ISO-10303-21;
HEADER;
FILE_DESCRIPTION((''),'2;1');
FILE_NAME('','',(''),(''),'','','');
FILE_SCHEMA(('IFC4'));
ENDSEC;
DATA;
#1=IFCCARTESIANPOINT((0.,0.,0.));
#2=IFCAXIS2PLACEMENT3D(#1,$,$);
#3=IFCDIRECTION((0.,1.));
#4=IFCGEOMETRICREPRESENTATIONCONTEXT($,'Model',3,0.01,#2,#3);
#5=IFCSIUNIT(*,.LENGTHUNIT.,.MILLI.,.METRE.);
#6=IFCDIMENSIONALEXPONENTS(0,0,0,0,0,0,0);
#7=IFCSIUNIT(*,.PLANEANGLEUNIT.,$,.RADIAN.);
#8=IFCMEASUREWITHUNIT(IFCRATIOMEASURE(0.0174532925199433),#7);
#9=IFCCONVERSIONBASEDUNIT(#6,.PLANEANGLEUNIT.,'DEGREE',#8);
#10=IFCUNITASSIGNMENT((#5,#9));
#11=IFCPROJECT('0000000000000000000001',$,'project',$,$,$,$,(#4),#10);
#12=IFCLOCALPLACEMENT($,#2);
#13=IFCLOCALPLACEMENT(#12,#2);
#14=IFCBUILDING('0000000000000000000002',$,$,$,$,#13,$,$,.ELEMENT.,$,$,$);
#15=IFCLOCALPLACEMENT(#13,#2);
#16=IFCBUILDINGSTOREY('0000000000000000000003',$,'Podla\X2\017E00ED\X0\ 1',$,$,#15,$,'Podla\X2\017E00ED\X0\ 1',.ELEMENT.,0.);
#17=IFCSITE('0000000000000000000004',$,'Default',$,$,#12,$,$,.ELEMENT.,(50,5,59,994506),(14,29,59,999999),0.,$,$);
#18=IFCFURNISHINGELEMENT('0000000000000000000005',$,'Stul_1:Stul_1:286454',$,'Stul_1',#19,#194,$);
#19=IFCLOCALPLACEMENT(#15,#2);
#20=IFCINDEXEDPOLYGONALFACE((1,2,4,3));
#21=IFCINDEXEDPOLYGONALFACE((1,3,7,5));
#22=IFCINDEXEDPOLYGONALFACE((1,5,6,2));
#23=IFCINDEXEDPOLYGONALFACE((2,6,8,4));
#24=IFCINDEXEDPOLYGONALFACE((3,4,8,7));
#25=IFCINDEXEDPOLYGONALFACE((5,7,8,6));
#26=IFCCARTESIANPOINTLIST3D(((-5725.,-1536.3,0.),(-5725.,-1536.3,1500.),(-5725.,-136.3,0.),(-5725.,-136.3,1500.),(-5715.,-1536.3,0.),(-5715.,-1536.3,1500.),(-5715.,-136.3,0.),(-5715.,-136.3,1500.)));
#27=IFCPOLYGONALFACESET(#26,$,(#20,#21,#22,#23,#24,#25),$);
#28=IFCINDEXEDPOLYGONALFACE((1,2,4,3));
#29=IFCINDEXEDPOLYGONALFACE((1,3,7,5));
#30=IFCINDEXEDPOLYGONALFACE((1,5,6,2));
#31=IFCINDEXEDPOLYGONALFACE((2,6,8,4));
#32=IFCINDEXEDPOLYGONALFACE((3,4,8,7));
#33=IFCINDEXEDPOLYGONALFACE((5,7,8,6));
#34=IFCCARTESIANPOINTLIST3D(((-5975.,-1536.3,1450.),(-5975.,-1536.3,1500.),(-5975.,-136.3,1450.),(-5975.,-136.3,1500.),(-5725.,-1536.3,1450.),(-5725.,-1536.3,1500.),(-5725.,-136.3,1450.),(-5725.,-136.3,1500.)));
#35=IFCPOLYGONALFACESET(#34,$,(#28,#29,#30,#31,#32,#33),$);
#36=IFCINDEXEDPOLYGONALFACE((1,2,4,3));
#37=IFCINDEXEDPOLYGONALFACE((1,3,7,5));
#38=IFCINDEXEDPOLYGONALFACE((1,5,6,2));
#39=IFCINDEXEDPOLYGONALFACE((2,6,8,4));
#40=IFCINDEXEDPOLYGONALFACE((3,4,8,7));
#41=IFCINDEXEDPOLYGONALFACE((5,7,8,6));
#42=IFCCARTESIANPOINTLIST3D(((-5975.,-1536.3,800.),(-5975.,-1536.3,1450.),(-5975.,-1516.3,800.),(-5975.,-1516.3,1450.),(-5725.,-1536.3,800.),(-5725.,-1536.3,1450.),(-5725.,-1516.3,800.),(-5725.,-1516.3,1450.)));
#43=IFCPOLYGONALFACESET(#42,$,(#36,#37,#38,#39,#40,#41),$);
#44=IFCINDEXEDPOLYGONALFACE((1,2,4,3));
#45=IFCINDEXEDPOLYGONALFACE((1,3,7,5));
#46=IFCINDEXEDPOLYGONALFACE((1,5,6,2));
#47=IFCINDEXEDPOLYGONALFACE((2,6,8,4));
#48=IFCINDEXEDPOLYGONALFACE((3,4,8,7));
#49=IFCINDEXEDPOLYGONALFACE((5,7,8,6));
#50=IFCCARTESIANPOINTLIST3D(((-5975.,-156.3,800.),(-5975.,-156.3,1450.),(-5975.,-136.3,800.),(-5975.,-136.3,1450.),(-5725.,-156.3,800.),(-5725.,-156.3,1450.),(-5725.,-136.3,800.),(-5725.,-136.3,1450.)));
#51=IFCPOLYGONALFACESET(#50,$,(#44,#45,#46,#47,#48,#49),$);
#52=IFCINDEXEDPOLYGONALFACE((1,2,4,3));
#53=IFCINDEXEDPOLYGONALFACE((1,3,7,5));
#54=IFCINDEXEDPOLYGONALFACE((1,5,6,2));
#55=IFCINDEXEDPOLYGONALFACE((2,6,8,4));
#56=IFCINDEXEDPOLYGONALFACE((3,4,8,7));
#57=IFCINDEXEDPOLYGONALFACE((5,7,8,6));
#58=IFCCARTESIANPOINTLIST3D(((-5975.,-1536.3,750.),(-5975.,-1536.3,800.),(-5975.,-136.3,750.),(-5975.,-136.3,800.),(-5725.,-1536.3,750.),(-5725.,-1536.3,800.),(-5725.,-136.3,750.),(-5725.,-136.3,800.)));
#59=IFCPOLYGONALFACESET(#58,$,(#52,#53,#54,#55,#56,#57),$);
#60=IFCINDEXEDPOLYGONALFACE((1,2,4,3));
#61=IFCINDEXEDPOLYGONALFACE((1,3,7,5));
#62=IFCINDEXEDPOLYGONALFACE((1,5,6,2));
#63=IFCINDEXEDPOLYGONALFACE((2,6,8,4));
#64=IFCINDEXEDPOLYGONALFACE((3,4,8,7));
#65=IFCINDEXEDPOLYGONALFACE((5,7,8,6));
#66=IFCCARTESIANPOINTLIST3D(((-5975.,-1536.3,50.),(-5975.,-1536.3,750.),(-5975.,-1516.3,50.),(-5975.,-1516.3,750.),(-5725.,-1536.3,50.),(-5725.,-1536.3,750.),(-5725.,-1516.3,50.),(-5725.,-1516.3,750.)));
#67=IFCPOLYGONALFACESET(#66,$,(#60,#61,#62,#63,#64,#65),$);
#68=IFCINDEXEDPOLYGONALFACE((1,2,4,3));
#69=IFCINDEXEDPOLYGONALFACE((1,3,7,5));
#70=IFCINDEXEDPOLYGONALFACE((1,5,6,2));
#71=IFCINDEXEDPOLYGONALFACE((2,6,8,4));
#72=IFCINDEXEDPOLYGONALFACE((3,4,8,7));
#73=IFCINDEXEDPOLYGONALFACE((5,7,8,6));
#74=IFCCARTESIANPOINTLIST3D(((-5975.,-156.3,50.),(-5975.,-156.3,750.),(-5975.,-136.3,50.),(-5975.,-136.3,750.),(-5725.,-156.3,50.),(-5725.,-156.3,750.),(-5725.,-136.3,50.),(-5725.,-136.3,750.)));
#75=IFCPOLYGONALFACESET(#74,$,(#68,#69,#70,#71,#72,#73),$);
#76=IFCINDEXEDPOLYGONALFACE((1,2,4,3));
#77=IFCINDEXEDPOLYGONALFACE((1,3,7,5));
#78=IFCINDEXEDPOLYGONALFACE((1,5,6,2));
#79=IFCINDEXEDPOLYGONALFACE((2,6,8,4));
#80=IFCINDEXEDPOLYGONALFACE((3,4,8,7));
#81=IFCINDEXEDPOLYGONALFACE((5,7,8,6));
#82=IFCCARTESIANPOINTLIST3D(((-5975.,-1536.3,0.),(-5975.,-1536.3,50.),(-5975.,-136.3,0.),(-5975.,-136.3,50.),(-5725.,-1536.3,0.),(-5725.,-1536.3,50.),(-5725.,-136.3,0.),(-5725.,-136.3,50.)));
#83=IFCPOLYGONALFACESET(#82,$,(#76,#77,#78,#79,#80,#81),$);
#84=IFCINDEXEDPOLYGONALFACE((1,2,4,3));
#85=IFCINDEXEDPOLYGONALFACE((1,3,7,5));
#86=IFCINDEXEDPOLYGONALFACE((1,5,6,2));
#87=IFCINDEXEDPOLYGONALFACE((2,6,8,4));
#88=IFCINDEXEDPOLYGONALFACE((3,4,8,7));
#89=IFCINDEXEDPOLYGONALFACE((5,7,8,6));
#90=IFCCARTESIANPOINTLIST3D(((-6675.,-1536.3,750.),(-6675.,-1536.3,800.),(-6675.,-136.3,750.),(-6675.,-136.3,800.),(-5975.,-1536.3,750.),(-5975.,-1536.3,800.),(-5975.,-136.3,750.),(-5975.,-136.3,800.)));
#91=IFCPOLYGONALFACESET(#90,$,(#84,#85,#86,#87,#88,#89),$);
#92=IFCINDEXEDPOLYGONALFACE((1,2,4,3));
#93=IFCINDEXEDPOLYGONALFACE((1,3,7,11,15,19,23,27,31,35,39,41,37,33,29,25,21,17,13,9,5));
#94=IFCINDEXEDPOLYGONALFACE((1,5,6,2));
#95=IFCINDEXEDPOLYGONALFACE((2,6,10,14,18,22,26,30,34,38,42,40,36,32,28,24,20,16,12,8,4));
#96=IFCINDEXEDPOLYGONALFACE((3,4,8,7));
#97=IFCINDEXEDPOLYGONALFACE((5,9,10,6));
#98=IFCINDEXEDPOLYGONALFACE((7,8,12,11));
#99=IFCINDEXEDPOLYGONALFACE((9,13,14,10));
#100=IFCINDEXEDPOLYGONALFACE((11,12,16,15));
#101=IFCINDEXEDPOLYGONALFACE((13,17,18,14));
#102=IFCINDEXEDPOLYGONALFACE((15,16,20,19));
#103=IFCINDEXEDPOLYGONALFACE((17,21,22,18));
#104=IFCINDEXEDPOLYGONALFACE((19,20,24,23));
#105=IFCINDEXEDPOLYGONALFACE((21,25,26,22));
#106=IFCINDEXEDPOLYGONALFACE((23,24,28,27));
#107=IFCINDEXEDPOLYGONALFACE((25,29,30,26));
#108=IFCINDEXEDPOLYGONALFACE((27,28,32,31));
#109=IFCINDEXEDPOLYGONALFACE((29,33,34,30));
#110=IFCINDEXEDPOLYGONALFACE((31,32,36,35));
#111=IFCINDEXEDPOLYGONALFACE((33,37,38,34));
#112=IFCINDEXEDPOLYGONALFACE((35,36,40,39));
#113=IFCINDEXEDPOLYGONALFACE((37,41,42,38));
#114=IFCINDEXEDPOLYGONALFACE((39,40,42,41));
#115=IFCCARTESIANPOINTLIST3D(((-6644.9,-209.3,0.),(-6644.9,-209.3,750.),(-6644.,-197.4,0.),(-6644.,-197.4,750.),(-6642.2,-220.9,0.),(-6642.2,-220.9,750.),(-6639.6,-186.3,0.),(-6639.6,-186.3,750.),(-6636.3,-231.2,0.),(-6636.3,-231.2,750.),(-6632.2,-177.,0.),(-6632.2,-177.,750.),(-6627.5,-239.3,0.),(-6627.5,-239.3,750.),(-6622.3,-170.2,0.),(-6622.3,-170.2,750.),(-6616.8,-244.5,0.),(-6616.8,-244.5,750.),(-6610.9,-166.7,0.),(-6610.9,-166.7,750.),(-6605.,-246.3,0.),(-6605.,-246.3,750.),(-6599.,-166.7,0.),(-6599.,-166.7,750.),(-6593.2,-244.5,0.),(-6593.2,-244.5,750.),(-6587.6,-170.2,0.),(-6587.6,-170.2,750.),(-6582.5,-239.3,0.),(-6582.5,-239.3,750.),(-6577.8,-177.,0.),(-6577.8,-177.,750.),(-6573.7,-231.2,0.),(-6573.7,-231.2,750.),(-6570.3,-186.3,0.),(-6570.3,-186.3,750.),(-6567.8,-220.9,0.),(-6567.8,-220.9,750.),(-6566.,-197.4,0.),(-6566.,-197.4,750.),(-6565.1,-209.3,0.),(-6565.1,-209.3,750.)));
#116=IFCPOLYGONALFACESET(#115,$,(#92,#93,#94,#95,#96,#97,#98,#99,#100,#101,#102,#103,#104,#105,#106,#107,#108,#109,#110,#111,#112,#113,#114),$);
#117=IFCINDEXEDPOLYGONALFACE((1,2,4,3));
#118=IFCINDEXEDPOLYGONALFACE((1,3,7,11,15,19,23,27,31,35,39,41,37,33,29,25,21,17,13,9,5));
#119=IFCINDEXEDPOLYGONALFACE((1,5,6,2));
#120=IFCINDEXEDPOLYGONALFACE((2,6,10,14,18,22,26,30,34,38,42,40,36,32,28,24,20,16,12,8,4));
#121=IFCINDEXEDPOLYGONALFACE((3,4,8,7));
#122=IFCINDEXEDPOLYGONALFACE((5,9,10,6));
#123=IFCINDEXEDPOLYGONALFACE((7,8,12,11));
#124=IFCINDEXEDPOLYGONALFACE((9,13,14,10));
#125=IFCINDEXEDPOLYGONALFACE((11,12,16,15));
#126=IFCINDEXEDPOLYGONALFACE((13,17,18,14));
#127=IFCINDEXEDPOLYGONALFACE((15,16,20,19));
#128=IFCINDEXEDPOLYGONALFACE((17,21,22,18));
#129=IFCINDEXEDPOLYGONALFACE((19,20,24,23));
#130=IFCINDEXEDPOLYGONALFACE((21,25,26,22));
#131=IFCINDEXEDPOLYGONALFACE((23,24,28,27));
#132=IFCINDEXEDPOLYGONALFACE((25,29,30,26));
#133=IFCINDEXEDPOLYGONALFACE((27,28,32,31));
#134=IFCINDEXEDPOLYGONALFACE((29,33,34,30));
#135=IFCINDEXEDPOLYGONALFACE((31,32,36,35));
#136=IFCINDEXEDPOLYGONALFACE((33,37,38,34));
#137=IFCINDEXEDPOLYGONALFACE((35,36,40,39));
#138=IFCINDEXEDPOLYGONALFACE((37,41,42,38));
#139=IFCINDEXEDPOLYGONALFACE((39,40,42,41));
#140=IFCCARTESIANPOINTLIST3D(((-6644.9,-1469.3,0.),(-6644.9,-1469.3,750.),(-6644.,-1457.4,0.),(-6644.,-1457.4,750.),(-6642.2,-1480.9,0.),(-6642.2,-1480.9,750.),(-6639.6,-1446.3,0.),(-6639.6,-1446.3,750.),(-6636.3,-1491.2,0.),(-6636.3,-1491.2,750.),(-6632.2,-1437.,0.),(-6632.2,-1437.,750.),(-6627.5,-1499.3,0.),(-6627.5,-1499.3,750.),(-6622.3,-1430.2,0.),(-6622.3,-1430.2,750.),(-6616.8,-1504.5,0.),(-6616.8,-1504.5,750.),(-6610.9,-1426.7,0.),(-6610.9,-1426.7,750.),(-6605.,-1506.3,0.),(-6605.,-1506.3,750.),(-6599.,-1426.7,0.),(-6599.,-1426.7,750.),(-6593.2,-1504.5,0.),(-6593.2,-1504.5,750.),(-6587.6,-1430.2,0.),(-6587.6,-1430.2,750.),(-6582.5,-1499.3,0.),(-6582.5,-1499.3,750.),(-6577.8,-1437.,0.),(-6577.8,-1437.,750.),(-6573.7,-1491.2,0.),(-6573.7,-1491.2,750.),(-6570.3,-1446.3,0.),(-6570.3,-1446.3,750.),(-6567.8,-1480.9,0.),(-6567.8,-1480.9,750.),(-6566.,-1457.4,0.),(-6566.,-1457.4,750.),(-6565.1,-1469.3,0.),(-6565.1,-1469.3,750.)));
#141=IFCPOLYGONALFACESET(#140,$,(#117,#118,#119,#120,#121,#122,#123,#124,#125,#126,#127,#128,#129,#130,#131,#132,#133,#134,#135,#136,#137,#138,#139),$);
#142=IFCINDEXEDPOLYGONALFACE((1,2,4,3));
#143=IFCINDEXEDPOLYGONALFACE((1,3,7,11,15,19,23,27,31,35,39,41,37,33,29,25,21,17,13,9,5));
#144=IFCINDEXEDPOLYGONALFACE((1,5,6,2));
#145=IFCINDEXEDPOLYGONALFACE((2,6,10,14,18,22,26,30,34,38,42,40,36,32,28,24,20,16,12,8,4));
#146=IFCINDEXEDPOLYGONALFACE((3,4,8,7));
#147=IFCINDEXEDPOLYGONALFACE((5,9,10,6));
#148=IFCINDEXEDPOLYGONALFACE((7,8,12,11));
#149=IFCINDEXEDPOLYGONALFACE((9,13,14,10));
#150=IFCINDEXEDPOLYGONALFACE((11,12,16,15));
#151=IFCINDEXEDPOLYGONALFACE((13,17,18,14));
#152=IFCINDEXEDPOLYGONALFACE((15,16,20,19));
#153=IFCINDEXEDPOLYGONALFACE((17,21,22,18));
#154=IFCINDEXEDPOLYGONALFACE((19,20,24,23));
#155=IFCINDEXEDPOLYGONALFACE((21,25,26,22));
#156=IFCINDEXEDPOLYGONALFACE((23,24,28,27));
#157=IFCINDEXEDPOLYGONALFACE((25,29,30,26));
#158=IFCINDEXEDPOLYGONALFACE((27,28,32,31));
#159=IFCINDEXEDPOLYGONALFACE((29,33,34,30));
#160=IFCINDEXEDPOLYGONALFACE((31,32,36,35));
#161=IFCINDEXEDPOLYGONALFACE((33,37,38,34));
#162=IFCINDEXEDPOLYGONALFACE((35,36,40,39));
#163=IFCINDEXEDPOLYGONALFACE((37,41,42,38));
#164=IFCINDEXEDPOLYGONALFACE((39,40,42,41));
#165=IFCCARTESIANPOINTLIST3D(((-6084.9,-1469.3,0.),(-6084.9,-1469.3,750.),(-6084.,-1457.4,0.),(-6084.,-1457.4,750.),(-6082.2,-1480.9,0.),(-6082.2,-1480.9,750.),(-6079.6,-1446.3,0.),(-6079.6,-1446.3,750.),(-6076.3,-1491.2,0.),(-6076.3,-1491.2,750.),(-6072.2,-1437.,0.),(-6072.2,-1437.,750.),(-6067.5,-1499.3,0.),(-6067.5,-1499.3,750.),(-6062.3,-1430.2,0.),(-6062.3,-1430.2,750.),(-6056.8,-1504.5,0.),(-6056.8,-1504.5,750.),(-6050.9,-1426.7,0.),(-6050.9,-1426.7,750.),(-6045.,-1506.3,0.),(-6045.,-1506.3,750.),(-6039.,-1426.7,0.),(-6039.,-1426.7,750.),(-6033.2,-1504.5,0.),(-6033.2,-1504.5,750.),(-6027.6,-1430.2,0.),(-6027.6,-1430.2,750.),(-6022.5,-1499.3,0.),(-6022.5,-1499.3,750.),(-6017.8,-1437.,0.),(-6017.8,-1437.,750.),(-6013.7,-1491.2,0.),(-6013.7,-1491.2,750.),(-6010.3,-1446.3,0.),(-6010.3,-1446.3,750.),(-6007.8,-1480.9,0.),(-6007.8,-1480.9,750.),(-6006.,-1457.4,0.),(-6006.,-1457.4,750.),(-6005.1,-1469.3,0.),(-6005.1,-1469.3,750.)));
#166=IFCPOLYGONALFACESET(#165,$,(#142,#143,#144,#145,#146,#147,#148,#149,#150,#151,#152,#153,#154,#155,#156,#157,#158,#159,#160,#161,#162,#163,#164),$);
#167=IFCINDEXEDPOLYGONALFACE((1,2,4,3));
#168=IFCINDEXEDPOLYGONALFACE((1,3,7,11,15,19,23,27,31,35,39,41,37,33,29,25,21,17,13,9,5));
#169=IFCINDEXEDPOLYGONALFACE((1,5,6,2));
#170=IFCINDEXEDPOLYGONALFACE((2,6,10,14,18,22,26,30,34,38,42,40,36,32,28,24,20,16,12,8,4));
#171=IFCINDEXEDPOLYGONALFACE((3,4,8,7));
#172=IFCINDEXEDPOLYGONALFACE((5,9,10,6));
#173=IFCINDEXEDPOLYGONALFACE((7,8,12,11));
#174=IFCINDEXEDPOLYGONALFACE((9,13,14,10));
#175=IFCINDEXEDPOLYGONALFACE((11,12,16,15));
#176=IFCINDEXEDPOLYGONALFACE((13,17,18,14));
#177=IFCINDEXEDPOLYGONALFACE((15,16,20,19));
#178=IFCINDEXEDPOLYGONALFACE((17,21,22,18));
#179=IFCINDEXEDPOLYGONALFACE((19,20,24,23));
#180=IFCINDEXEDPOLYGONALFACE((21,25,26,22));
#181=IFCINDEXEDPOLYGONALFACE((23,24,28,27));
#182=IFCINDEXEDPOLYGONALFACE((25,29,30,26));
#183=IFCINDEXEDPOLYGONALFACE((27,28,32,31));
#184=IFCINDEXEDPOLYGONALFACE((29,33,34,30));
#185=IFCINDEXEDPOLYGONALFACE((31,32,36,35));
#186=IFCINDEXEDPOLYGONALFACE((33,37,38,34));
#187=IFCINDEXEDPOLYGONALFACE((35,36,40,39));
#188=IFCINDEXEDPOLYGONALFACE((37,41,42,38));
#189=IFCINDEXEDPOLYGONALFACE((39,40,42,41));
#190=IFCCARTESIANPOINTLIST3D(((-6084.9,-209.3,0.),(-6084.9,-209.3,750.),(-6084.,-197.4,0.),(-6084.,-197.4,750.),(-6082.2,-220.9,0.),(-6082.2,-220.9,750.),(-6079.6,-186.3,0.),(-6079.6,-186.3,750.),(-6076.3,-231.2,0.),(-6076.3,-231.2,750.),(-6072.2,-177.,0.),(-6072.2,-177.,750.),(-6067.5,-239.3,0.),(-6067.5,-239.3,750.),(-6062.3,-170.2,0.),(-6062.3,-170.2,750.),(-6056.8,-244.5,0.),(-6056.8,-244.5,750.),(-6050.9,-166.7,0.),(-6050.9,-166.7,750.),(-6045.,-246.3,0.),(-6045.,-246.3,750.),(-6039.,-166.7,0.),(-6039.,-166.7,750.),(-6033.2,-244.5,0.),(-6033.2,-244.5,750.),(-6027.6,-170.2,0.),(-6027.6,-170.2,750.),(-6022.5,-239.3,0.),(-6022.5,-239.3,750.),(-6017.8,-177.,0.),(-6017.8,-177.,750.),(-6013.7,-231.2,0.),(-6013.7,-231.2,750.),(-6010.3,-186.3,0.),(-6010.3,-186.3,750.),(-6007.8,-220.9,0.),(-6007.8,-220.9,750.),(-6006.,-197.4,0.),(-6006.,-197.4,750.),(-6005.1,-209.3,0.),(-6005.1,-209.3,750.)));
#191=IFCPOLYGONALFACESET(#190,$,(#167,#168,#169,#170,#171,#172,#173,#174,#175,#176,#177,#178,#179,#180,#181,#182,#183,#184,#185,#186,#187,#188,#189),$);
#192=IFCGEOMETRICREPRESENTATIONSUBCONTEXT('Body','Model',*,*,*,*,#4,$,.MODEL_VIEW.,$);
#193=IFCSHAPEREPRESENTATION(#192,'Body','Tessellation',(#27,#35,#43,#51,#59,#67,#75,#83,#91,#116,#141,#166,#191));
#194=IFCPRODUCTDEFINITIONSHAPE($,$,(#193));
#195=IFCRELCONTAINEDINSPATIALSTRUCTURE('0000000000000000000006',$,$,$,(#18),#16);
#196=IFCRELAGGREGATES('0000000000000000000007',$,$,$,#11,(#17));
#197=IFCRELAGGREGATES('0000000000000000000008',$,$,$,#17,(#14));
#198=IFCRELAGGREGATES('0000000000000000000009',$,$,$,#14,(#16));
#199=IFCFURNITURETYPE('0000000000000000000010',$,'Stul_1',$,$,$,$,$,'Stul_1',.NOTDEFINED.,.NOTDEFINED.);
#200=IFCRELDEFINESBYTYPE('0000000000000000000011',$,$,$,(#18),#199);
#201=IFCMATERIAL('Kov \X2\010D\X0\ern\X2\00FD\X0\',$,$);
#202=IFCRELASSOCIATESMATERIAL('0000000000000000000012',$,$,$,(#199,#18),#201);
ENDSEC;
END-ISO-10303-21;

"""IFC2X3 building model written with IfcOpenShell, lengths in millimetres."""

from ifc_helpers import new_model, entity, si_unit, converted_unit, direction, frame, frame_2d, origin, origin_2d_with_axis, place, context, subcontext, project, spatial, rectangle, circle, extrude, source, transform, mapped, material, type_object, type_shapes, element, save


model = new_model("IFC2X3")

# Units and contexts
model_context = context("Model", 3, precision=0.01, world=origin(), true_north=direction((0.0, 1.0)))
body_context = subcontext(model_context, "Body", "Model", "MODEL_VIEW")
ifc_project = project(units=[si_unit("LENGTHUNIT", "METRE", prefix="MILLI"), converted_unit("PLANEANGLEUNIT", "DEGREE", entity("IfcRatioMeasure", 0.0174532925199433), si_unit("PLANEANGLEUNIT", "RADIAN"), dimensions=[0, 0, 0, 0, 0, 0, 0])], contexts=[model_context])

# Site, building, storey
site_placement = place(None, origin())
site = spatial("IfcSite", under=ifc_project, at=site_placement, Name="Default", CompositionType="ELEMENT", RefLatitude=(50, 5, 59, 994506), RefLongitude=(14, 29, 59, 999999), RefElevation=0.0)
building_placement = place(site_placement, origin())
building = spatial("IfcBuilding", under=site, at=building_placement, CompositionType="ELEMENT")
storey_placement = place(building_placement, origin())
storey = spatial("IfcBuildingStorey", under=building, at=storey_placement, Name="Podlaží 1", LongName="Podlaží 1", CompositionType="ELEMENT", Elevation=0.0)

# Furnishing element
ifc_material_1 = material(Name="Kov černý")
furniture_type = type_object("IfcFurnitureType", Name="Stul_1", ElementType="Stul_1", material=ifc_material_1)
shared_shape_1 = source(origin(), body_context, "Body", "SweptSolid", [
    extrude(rectangle(XDim=1400.0, YDim=10.0, at=origin_2d_with_axis()), frame((0.0, 605.0, 0.0), z_axis=(0.0, 0.0, 1.0), x_axis=(-1.0, 0.0, 0.0)), (0.0, 0.0, 1.0), 1500.0),
    extrude(rectangle(XDim=1400.0, YDim=250.0, at=frame_2d((0.0, 0.0), x_axis=(1.0, 0.0))), frame((0.0, 475.0, 1450.0), z_axis=(0.0, 0.0, 1.0), x_axis=(-1.0, 0.0, 0.0)), (0.0, 0.0, 1.0), 50.0),
    extrude(rectangle(XDim=20.0, YDim=250.0, at=origin_2d_with_axis()), frame((690.0, 475.0, 800.0), z_axis=(0.0, 0.0, 1.0), x_axis=(-1.0, 0.0, 0.0)), (0.0, 0.0, 1.0), 650.0),
    extrude(rectangle(XDim=20.0, YDim=250.0, at=frame_2d((0.0, 0.0), x_axis=(1.0, 0.0))), frame((-690.0, 475.0, 800.0), z_axis=(0.0, 0.0, 1.0), x_axis=(-1.0, 0.0, 0.0)), (0.0, 0.0, 1.0), 650.0),
    extrude(rectangle(XDim=1400.0, YDim=250.0, at=origin_2d_with_axis()), frame((0.0, 475.0, 750.0), z_axis=(0.0, 0.0, 1.0), x_axis=(-1.0, 0.0, 0.0)), (0.0, 0.0, 1.0), 50.0),
    extrude(rectangle(XDim=20.0, YDim=250.0, at=origin_2d_with_axis()), frame((690.0, 475.0, 50.0), z_axis=(0.0, 0.0, 1.0), x_axis=(-1.0, 0.0, 0.0)), (0.0, 0.0, 1.0), 700.0),
    extrude(rectangle(XDim=20.0, YDim=250.0, at=frame_2d((0.0, 0.0), x_axis=(1.0, 0.0))), frame((-690.0, 475.0, 50.0), z_axis=(0.0, 0.0, 1.0), x_axis=(-1.0, 0.0, 0.0)), (0.0, 0.0, 1.0), 700.0),
    extrude(rectangle(XDim=1400.0, YDim=250.0, at=origin_2d_with_axis()), frame((0.0, 475.0, 0.0), z_axis=(0.0, 0.0, 1.0), x_axis=(-1.0, 0.0, 0.0)), (0.0, 0.0, 1.0), 50.0),
    extrude(rectangle(XDim=1400.0, YDim=700.0, at=origin_2d_with_axis()), frame((0.0, 0.0, 750.0), z_axis=(0.0, 0.0, 1.0), x_axis=(-1.0, 0.0, 0.0)), (0.0, 0.0, 1.0), 50.0),
    extrude(circle(Radius=40.0, at=frame_2d((0.0, 0.0), x_axis=(1.0, 0.0))), frame((-630.0, -280.0, 0.0)), (0.0, 0.0, 1.0), 750.0),
    extrude(circle(Radius=40.0, at=frame_2d((0.0, 0.0), x_axis=(1.0, 0.0))), frame((630.0, -280.0, 0.0)), (0.0, 0.0, 1.0), 750.0),
    extrude(circle(Radius=40.0, at=frame_2d((0.0, 0.0), x_axis=(1.0, 0.0))), frame((630.0, 280.0, 0.0)), (0.0, 0.0, 1.0), 750.0),
    extrude(circle(Radius=40.0, at=frame_2d((0.0, 0.0), x_axis=(1.0, 0.0))), frame((-630.0, 280.0, 0.0)), (0.0, 0.0, 1.0), 750.0),
])
type_shapes(furniture_type, [shared_shape_1])
for number, where, z_axis, x_axis, name in (
    (1, (-6325.0, -836.3, 0.0), (0.0, 0.0, 1.0), (0.0, -1.0, 0.0), "Stul_1:Stul_1:286454"),
):
    element("IfcFurnishingElement", number, at=place(storey_placement, frame(where, z_axis=z_axis, x_axis=x_axis)), inside=storey, type_object=furniture_type, material=ifc_material_1, Name=name, ObjectType="Stul_1", context=body_context, shape_type="MappedRepresentation", body=[
        mapped(shared_shape_1, transform((0.0, 0.0, 0.0), scale=1.0)),
    ])

save(model, "model.ifc")
